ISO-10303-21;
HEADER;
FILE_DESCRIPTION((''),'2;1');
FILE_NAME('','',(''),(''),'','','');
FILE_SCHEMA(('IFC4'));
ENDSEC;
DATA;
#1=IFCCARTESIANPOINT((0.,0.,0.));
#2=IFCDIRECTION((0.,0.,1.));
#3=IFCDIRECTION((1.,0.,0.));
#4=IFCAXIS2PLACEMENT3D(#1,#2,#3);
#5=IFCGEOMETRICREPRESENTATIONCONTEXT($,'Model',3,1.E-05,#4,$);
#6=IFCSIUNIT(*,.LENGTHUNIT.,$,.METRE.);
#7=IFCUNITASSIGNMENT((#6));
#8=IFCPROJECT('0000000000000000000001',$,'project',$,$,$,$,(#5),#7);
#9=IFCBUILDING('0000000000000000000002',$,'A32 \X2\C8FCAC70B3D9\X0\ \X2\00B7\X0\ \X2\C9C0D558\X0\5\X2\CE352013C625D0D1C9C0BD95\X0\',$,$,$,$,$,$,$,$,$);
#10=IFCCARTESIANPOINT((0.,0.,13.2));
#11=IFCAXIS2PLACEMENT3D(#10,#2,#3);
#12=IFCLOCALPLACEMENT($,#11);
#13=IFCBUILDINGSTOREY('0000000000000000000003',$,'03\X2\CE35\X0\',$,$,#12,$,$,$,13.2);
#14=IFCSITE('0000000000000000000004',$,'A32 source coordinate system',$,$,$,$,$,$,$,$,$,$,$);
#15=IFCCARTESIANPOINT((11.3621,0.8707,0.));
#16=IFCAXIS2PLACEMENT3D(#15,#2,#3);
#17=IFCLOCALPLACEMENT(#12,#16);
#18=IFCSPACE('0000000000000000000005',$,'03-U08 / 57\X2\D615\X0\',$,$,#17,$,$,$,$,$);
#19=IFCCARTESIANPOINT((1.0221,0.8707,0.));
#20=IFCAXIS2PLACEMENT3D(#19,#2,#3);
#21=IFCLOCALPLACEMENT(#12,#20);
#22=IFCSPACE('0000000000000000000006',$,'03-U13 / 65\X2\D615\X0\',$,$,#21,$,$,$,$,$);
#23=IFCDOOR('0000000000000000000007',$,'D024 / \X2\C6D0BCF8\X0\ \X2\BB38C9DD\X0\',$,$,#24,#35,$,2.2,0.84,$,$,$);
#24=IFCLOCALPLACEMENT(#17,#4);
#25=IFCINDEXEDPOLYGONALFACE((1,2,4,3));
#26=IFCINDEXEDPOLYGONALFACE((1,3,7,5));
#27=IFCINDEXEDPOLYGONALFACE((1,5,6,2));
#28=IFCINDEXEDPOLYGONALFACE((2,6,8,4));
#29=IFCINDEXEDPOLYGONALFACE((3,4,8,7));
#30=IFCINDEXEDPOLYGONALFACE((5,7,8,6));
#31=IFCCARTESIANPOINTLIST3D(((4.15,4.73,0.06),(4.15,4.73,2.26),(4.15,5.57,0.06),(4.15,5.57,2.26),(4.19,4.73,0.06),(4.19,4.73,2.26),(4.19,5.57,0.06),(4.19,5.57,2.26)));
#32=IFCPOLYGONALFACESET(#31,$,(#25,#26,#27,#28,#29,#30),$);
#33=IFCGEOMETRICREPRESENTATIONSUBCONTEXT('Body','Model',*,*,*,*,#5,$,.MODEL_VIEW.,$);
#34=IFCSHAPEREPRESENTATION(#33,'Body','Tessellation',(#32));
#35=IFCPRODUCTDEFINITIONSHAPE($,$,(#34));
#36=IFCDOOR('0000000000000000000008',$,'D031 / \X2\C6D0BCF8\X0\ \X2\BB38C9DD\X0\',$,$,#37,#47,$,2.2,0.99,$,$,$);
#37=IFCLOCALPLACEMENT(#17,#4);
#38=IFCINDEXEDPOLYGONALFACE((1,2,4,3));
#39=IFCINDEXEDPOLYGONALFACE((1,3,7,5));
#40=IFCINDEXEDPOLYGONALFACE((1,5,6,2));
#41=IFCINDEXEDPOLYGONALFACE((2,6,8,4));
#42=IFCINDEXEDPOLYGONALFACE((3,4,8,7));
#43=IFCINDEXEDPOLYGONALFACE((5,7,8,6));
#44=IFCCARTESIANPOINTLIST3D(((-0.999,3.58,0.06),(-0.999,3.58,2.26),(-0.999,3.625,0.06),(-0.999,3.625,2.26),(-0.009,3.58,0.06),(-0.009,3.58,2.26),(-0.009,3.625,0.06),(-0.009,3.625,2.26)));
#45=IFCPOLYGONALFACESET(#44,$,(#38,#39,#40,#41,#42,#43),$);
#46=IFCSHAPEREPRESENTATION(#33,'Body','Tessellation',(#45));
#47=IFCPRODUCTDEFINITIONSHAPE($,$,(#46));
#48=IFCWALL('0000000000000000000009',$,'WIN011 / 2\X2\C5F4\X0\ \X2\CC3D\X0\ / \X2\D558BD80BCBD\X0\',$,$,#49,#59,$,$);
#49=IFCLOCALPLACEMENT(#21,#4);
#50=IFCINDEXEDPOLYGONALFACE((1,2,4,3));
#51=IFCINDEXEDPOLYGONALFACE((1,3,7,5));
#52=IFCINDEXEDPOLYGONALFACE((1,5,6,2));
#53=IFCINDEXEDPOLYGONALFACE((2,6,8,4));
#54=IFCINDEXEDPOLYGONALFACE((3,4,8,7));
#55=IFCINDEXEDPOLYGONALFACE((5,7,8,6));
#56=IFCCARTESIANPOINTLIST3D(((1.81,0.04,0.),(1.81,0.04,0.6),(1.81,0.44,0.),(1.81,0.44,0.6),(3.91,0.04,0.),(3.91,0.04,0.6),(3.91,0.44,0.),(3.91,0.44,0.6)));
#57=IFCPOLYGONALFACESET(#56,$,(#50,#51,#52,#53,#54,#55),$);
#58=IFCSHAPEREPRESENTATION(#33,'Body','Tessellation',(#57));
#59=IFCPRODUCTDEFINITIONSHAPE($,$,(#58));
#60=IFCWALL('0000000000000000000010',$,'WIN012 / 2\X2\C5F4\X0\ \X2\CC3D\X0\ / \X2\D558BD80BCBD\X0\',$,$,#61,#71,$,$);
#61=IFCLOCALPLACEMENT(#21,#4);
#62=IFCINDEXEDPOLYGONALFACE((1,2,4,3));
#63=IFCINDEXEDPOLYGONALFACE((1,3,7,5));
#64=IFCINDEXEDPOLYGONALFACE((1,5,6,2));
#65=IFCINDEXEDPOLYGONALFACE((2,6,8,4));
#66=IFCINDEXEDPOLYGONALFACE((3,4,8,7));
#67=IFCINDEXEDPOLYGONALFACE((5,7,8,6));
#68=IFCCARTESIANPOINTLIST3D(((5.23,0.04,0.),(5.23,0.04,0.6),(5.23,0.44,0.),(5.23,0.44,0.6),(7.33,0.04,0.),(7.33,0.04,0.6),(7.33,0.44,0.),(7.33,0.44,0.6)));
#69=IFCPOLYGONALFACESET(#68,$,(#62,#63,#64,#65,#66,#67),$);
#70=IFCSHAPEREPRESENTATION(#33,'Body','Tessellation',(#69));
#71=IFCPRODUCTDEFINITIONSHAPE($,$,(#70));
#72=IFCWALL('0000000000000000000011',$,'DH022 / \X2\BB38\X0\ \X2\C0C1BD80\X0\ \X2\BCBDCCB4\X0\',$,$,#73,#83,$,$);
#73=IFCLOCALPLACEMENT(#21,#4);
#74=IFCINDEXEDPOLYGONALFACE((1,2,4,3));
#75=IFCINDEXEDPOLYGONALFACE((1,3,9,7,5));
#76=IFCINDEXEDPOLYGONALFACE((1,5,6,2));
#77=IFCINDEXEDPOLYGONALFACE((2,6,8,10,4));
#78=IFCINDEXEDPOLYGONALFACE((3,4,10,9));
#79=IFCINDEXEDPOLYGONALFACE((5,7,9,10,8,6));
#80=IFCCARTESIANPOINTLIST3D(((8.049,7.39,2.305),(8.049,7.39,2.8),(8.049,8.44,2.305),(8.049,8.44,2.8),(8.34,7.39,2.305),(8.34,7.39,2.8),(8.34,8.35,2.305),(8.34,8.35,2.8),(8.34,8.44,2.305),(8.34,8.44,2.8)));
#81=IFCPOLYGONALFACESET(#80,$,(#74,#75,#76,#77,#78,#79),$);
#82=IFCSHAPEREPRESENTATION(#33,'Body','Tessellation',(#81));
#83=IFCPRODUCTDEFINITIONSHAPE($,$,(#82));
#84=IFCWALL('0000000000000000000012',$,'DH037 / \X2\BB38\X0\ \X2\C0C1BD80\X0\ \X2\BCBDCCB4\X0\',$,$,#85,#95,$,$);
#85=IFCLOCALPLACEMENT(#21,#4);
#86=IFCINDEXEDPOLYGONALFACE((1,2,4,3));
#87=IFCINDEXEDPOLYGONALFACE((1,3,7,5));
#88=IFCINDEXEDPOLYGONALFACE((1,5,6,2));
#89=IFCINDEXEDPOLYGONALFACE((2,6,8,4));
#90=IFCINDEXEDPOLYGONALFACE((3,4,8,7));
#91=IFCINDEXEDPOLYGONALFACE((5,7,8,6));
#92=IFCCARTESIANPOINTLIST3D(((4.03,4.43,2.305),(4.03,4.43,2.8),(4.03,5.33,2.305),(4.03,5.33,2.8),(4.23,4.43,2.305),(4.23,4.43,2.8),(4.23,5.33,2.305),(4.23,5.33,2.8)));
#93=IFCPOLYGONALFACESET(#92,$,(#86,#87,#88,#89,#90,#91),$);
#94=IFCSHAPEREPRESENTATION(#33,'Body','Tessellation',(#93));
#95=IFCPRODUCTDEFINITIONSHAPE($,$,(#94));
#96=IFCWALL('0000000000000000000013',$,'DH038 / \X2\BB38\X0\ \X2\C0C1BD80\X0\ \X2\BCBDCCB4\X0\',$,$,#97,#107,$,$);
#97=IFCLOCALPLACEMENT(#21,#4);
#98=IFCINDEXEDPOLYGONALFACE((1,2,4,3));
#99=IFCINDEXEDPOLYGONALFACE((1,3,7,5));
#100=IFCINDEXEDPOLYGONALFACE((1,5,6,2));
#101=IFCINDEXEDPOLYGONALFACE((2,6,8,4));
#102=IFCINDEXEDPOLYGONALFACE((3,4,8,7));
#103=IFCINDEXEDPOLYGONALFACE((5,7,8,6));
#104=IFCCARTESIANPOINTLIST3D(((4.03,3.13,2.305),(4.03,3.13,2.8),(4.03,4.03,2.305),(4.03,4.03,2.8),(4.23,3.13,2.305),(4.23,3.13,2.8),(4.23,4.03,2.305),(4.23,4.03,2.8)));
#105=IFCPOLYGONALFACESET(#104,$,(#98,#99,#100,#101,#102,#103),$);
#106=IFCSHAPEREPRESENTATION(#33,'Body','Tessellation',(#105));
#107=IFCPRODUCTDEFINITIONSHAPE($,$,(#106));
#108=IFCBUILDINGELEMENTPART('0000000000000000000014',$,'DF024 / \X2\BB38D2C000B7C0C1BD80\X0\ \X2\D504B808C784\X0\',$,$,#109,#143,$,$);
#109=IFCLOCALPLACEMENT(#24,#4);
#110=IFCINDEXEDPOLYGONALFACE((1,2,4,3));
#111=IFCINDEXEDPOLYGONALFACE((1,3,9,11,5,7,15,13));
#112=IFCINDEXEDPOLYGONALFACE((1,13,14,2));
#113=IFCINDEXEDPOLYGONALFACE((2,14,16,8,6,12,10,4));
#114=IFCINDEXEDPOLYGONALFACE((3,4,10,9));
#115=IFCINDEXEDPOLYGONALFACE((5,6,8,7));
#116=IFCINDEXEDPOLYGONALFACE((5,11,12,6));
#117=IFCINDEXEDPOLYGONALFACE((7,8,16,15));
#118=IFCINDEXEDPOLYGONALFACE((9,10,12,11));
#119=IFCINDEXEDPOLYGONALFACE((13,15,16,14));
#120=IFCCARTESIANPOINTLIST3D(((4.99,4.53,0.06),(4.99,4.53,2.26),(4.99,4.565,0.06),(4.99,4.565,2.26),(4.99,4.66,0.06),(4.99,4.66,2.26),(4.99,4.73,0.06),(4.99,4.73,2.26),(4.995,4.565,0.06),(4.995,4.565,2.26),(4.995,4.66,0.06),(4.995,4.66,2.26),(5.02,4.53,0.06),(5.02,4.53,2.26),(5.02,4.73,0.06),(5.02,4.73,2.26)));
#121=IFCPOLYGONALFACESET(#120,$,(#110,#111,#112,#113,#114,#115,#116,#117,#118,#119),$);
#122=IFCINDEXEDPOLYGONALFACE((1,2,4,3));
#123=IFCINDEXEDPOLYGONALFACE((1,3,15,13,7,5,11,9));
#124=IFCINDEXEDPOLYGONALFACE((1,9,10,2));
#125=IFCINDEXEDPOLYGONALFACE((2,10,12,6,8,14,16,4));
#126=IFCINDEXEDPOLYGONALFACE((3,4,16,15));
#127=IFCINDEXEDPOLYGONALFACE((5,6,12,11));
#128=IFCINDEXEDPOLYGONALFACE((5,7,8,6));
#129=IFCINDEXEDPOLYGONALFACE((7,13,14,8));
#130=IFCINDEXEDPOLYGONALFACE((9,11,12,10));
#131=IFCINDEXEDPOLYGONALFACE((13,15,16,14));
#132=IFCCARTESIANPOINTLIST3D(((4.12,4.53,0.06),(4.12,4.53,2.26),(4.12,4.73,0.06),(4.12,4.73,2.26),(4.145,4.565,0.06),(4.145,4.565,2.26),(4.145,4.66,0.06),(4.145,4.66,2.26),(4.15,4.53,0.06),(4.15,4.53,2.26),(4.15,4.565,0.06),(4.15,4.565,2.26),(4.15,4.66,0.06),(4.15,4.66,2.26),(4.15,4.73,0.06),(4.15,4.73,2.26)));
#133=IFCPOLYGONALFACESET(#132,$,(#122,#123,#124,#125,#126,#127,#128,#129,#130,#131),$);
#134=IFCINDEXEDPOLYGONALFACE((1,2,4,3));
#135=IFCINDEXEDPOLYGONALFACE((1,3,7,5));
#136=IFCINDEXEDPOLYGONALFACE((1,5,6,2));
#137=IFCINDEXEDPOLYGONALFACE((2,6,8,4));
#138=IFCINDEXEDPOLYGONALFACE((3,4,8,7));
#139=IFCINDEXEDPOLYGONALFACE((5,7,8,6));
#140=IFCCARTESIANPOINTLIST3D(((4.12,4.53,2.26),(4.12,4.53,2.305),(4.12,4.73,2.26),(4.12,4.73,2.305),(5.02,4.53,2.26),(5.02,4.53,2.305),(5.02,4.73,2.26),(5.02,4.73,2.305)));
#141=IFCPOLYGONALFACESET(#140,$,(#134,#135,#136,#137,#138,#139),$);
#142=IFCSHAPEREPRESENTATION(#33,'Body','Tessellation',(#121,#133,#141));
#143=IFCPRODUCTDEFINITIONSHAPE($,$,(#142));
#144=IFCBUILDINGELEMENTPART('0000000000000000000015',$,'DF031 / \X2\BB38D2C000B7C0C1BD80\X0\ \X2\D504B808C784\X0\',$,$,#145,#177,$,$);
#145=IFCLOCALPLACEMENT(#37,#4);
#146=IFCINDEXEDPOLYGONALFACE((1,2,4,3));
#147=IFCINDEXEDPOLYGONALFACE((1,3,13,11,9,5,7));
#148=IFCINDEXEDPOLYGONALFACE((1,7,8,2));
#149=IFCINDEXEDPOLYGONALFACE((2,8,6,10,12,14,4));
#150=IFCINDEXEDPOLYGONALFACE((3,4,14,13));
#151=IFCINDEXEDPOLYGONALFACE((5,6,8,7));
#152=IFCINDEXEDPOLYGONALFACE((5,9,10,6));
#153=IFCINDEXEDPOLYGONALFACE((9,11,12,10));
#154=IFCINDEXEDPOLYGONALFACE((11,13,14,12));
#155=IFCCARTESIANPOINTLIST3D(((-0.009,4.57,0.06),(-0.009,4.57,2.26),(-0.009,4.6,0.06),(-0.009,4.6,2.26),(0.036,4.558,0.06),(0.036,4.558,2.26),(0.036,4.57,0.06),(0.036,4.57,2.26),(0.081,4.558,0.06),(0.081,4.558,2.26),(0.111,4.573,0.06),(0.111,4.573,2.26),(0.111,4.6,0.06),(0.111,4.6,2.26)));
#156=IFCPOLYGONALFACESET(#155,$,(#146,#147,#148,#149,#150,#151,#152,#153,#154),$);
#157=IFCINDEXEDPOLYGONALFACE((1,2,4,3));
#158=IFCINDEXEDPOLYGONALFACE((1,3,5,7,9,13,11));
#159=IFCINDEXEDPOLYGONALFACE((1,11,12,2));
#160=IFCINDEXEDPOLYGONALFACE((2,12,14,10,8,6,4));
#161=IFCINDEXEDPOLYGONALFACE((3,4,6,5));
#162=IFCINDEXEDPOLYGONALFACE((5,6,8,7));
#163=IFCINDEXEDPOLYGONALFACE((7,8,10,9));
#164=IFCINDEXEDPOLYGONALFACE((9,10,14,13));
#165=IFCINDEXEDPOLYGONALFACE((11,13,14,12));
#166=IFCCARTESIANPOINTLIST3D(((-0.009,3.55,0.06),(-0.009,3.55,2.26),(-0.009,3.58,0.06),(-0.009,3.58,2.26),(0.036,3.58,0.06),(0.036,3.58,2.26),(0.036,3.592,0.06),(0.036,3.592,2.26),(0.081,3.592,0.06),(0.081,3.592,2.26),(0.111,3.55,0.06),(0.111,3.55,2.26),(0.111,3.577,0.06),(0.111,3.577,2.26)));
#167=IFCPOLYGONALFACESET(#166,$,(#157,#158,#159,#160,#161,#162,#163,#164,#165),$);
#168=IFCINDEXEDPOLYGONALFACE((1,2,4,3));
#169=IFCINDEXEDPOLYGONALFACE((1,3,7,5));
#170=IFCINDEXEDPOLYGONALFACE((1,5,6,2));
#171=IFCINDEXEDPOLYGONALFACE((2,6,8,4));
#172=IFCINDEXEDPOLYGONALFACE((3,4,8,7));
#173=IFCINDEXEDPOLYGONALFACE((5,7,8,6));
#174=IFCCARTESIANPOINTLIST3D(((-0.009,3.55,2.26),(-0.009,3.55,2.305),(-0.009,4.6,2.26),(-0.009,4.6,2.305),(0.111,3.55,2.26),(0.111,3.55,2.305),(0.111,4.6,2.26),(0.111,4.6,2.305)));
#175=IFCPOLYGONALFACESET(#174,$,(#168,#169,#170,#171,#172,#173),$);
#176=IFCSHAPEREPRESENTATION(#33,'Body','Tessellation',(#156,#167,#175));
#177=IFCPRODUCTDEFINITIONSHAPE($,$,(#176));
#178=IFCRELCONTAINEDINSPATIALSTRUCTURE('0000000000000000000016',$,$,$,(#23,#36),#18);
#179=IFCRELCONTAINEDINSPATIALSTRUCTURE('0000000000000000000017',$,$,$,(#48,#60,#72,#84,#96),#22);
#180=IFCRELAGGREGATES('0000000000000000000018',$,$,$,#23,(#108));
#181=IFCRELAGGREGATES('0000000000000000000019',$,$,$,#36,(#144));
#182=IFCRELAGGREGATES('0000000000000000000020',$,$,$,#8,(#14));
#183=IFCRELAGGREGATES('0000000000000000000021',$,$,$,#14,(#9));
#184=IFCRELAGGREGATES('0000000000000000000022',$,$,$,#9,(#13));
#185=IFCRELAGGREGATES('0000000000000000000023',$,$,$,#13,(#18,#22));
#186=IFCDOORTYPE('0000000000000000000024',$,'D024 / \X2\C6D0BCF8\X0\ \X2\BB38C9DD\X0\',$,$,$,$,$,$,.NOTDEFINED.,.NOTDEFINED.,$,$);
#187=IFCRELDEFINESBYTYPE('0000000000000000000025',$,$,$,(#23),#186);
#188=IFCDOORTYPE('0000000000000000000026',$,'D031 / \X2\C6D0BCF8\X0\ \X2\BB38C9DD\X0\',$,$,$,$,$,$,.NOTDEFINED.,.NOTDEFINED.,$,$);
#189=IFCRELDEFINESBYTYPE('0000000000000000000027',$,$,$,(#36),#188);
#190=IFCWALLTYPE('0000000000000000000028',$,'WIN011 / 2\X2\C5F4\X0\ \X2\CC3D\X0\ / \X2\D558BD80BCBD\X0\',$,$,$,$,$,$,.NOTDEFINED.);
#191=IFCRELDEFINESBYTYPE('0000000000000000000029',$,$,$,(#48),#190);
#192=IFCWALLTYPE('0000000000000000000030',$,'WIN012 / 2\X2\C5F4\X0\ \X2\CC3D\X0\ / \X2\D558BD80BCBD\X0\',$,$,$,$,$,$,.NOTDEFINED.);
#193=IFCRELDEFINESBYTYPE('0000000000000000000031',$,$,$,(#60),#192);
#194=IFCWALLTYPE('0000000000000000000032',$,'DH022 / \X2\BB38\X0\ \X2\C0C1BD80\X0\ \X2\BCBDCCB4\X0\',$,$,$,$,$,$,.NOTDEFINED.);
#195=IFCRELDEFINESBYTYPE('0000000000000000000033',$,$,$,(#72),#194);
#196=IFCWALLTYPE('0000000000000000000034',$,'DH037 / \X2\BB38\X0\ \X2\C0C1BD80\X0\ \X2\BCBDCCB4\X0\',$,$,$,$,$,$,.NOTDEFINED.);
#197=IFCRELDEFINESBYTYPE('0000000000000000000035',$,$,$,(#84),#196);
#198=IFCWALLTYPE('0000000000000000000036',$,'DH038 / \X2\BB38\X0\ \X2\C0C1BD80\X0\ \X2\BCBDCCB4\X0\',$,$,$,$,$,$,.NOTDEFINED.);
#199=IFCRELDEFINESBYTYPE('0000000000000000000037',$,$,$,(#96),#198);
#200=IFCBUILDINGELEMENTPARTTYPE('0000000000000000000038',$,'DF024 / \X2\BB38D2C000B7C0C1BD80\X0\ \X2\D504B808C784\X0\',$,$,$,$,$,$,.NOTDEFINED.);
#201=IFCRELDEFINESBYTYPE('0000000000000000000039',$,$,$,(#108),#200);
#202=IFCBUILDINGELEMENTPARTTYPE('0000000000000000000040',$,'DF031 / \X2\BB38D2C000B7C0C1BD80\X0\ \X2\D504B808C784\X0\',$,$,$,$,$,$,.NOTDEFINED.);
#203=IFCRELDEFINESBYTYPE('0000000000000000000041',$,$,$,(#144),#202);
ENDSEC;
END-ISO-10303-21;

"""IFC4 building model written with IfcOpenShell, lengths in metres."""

from ifc_helpers import new_model, si_unit, frame, origin, origin_with_axes, place, context, subcontext, project, spatial, polyline, outline, extrude, source, transform, mapped, type_object, type_shapes, element, aggregate, save


model = new_model("IFC4")

# Units and contexts
model_context = context("Model", 3, precision=1e-05, world=origin_with_axes())
body_context = subcontext(model_context, "Body", "Model", "MODEL_VIEW")
ifc_project = project(units=[si_unit("LENGTHUNIT", "METRE")], contexts=[model_context])

# Site, building, storey, space
storey_placement = place(None, frame((0.0, 0.0, 13.2), z_axis=(0.0, 0.0, 1.0), x_axis=(1.0, 0.0, 0.0)))
space_1_placement = place(storey_placement, frame((11.3621, 0.8707, 0.0), z_axis=(0.0, 0.0, 1.0), x_axis=(1.0, 0.0, 0.0)))
site = spatial("IfcSite", under=ifc_project, Name="A32 source coordinate system")
building = spatial("IfcBuilding", under=site, Name="A32 주거동 · 지하5층–옥탑지붕")
storey = spatial("IfcBuildingStorey", under=building, at=storey_placement, Name="03층", Elevation=13.2)
space_1 = spatial("IfcSpace", under=storey, at=space_1_placement, Name="03-U08 / 57형")

# Doors
door_type_1 = type_object("IfcDoorType", Name="D024 / 원본 문짝", OperationType="NOTDEFINED", PredefinedType="NOTDEFINED")
shared_shape_1 = source(origin(), body_context, "Body", "SweptSolid", [
    extrude(outline(polyline([(4.15, 4.73), (4.15, 5.57), (4.19, 5.57), (4.19, 4.73), (4.15, 4.73)])), frame((0.0, 0.0, 0.06)), (0.0, 0.0, 1.0), 2.2),
])
type_shapes(door_type_1, [shared_shape_1])
door_1_placement = place(space_1_placement, origin_with_axes())
door_1 = element("IfcDoor", 1, at=door_1_placement, inside=space_1, type_object=door_type_1, Name="D024 / 원본 문짝", OverallHeight=2.2, OverallWidth=0.84, context=body_context, shape_type="MappedRepresentation", body=[
    mapped(shared_shape_1, transform((0.0, 0.0, 0.0), scale=1.0)),
])
door_type_2 = type_object("IfcDoorType", Name="D031 / 원본 문짝", OperationType="NOTDEFINED", PredefinedType="NOTDEFINED")
shared_shape_2 = source(origin(), body_context, "Body", "SweptSolid", [
    extrude(outline(polyline([(-0.009, 3.58), (-0.999, 3.58), (-0.999, 3.625), (-0.009, 3.625), (-0.009, 3.58)])), frame((0.0, 0.0, 0.06)), (0.0, 0.0, 1.0), 2.2),
])
type_shapes(door_type_2, [shared_shape_2])
door_2_placement = place(space_1_placement, origin_with_axes())
door_2 = element("IfcDoor", 2, at=door_2_placement, inside=space_1, type_object=door_type_2, Name="D031 / 원본 문짝", OverallHeight=2.2, OverallWidth=0.99, context=body_context, shape_type="MappedRepresentation", body=[
    mapped(shared_shape_2, transform((0.0, 0.0, 0.0), scale=1.0)),
])

# Shared definitions
space_2_placement = place(storey_placement, frame((1.0221, 0.8707, 0.0), z_axis=(0.0, 0.0, 1.0), x_axis=(1.0, 0.0, 0.0)))
space_2 = spatial("IfcSpace", under=storey, at=space_2_placement, Name="03-U13 / 65형")

# Walls
wall_type_1 = type_object("IfcWallType", Name="WIN011 / 2열 창 / 하부벽", PredefinedType="NOTDEFINED")
shared_shape_3 = source(origin(), body_context, "Body", "SweptSolid", [
    extrude(outline(polyline([(1.81, 0.44), (3.91, 0.44), (3.91, 0.04), (1.81, 0.04), (1.81, 0.44)])), origin(), (0.0, 0.0, 1.0), 0.6),
])
type_shapes(wall_type_1, [shared_shape_3])
wall_1_placement = place(space_2_placement, origin_with_axes())
element("IfcWall", 3, at=wall_1_placement, inside=space_2, type_object=wall_type_1, Name="WIN011 / 2열 창 / 하부벽", context=body_context, shape_type="MappedRepresentation", body=[
    mapped(shared_shape_3, transform((0.0, 0.0, 0.0), scale=1.0)),
])
wall_type_2 = type_object("IfcWallType", Name="WIN012 / 2열 창 / 하부벽", PredefinedType="NOTDEFINED")
shared_shape_4 = source(origin(), body_context, "Body", "SweptSolid", [
    extrude(outline(polyline([(5.23, 0.44), (7.33, 0.44), (7.33, 0.04), (5.23, 0.04), (5.23, 0.44)])), origin(), (0.0, 0.0, 1.0), 0.6),
])
type_shapes(wall_type_2, [shared_shape_4])
wall_2_placement = place(space_2_placement, origin_with_axes())
element("IfcWall", 4, at=wall_2_placement, inside=space_2, type_object=wall_type_2, Name="WIN012 / 2열 창 / 하부벽", context=body_context, shape_type="MappedRepresentation", body=[
    mapped(shared_shape_4, transform((0.0, 0.0, 0.0), scale=1.0)),
])
wall_type_3 = type_object("IfcWallType", Name="DH022 / 문 상부 벽체", PredefinedType="NOTDEFINED")
shared_shape_5 = source(origin(), body_context, "Body", "SweptSolid", [
    extrude(outline(polyline([(8.049, 7.39), (8.049, 8.44), (8.34, 8.44), (8.34, 8.35), (8.34, 8.35), (8.34, 7.39), (8.049, 7.39)])), frame((0.0, 0.0, 2.305)), (0.0, 0.0, 1.0), 0.495),
])
type_shapes(wall_type_3, [shared_shape_5])
wall_3_placement = place(space_2_placement, origin_with_axes())
element("IfcWall", 5, at=wall_3_placement, inside=space_2, type_object=wall_type_3, Name="DH022 / 문 상부 벽체", context=body_context, shape_type="MappedRepresentation", body=[
    mapped(shared_shape_5, transform((0.0, 0.0, 0.0), scale=1.0)),
])
wall_type_4 = type_object("IfcWallType", Name="DH037 / 문 상부 벽체", PredefinedType="NOTDEFINED")
shared_shape_6 = source(origin(), body_context, "Body", "SweptSolid", [
    extrude(outline(polyline([(4.23, 5.33), (4.23, 4.43), (4.03, 4.43), (4.03, 5.33), (4.23, 5.33)])), frame((0.0, 0.0, 2.305)), (0.0, 0.0, 1.0), 0.495),
])
type_shapes(wall_type_4, [shared_shape_6])
wall_4_placement = place(space_2_placement, origin_with_axes())
element("IfcWall", 6, at=wall_4_placement, inside=space_2, type_object=wall_type_4, Name="DH037 / 문 상부 벽체", context=body_context, shape_type="MappedRepresentation", body=[
    mapped(shared_shape_6, transform((0.0, 0.0, 0.0), scale=1.0)),
])
wall_type_5 = type_object("IfcWallType", Name="DH038 / 문 상부 벽체", PredefinedType="NOTDEFINED")
shared_shape_7 = source(origin(), body_context, "Body", "SweptSolid", [
    extrude(outline(polyline([(4.23, 4.03), (4.23, 3.13), (4.03, 3.13), (4.03, 4.03), (4.23, 4.03)])), frame((0.0, 0.0, 2.305)), (0.0, 0.0, 1.0), 0.495),
])
type_shapes(wall_type_5, [shared_shape_7])
wall_5_placement = place(space_2_placement, origin_with_axes())
element("IfcWall", 7, at=wall_5_placement, inside=space_2, type_object=wall_type_5, Name="DH038 / 문 상부 벽체", context=body_context, shape_type="MappedRepresentation", body=[
    mapped(shared_shape_7, transform((0.0, 0.0, 0.0), scale=1.0)),
])

# Building element parts
building_element_part_type_1 = type_object("IfcBuildingElementPartType", Name="DF024 / 문틀·상부 프레임", PredefinedType="NOTDEFINED")
shared_shape_8 = source(origin(), body_context, "Body", "SweptSolid", [
    extrude(outline(polyline([(5.02, 4.53), (4.99, 4.53), (4.99, 4.565), (4.995, 4.565), (4.995, 4.66), (4.99, 4.66), (4.99, 4.73), (5.02, 4.73), (5.02, 4.53)])), frame((0.0, 0.0, 0.06)), (0.0, 0.0, 1.0), 2.2),
    extrude(outline(polyline([(4.15, 4.73), (4.15, 4.66), (4.145, 4.66), (4.145, 4.565), (4.15, 4.565), (4.15, 4.53), (4.12, 4.53), (4.12, 4.73), (4.15, 4.73)])), frame((0.0, 0.0, 0.06)), (0.0, 0.0, 1.0), 2.2),
    extrude(outline(polyline([(4.12, 4.53), (4.12, 4.73), (5.02, 4.73), (5.02, 4.53), (4.12, 4.53)])), frame((0.0, 0.0, 2.26)), (0.0, 0.0, 1.0), 0.045),
])
type_shapes(building_element_part_type_1, [shared_shape_8])
building_element_part_1_placement = place(door_1_placement, origin_with_axes())
building_element_part_1 = element("IfcBuildingElementPart", 8, at=building_element_part_1_placement, type_object=building_element_part_type_1, Name="DF024 / 문틀·상부 프레임", context=body_context, shape_type="MappedRepresentation", body=[
    mapped(shared_shape_8, transform((0.0, 0.0, 0.0), scale=1.0)),
])
aggregate(door_1, [building_element_part_1])
building_element_part_type_2 = type_object("IfcBuildingElementPartType", Name="DF031 / 문틀·상부 프레임", PredefinedType="NOTDEFINED")
shared_shape_9 = source(origin(), body_context, "Body", "SweptSolid", [
    extrude(outline(polyline([(0.111, 4.6), (0.111, 4.573), (0.081, 4.558), (0.036, 4.558), (0.036, 4.57), (-0.009, 4.57), (-0.009, 4.6), (0.111, 4.6)])), frame((0.0, 0.0, 0.06)), (0.0, 0.0, 1.0), 2.2),
    extrude(outline(polyline([(-0.009, 3.58), (0.036, 3.58), (0.036, 3.592), (0.081, 3.592), (0.111, 3.577), (0.111, 3.55), (-0.009, 3.55), (-0.009, 3.58)])), frame((0.0, 0.0, 0.06)), (0.0, 0.0, 1.0), 2.2),
    extrude(outline(polyline([(-0.009, 3.55), (-0.009, 4.6), (0.111, 4.6), (0.111, 3.55), (-0.009, 3.55)])), frame((0.0, 0.0, 2.26)), (0.0, 0.0, 1.0), 0.045),
])
type_shapes(building_element_part_type_2, [shared_shape_9])
building_element_part_2_placement = place(door_2_placement, origin_with_axes())
building_element_part_2 = element("IfcBuildingElementPart", 9, at=building_element_part_2_placement, type_object=building_element_part_type_2, Name="DF031 / 문틀·상부 프레임", context=body_context, shape_type="MappedRepresentation", body=[
    mapped(shared_shape_9, transform((0.0, 0.0, 0.0), scale=1.0)),
])
aggregate(door_2, [building_element_part_2])

save(model, "model.ifc")
